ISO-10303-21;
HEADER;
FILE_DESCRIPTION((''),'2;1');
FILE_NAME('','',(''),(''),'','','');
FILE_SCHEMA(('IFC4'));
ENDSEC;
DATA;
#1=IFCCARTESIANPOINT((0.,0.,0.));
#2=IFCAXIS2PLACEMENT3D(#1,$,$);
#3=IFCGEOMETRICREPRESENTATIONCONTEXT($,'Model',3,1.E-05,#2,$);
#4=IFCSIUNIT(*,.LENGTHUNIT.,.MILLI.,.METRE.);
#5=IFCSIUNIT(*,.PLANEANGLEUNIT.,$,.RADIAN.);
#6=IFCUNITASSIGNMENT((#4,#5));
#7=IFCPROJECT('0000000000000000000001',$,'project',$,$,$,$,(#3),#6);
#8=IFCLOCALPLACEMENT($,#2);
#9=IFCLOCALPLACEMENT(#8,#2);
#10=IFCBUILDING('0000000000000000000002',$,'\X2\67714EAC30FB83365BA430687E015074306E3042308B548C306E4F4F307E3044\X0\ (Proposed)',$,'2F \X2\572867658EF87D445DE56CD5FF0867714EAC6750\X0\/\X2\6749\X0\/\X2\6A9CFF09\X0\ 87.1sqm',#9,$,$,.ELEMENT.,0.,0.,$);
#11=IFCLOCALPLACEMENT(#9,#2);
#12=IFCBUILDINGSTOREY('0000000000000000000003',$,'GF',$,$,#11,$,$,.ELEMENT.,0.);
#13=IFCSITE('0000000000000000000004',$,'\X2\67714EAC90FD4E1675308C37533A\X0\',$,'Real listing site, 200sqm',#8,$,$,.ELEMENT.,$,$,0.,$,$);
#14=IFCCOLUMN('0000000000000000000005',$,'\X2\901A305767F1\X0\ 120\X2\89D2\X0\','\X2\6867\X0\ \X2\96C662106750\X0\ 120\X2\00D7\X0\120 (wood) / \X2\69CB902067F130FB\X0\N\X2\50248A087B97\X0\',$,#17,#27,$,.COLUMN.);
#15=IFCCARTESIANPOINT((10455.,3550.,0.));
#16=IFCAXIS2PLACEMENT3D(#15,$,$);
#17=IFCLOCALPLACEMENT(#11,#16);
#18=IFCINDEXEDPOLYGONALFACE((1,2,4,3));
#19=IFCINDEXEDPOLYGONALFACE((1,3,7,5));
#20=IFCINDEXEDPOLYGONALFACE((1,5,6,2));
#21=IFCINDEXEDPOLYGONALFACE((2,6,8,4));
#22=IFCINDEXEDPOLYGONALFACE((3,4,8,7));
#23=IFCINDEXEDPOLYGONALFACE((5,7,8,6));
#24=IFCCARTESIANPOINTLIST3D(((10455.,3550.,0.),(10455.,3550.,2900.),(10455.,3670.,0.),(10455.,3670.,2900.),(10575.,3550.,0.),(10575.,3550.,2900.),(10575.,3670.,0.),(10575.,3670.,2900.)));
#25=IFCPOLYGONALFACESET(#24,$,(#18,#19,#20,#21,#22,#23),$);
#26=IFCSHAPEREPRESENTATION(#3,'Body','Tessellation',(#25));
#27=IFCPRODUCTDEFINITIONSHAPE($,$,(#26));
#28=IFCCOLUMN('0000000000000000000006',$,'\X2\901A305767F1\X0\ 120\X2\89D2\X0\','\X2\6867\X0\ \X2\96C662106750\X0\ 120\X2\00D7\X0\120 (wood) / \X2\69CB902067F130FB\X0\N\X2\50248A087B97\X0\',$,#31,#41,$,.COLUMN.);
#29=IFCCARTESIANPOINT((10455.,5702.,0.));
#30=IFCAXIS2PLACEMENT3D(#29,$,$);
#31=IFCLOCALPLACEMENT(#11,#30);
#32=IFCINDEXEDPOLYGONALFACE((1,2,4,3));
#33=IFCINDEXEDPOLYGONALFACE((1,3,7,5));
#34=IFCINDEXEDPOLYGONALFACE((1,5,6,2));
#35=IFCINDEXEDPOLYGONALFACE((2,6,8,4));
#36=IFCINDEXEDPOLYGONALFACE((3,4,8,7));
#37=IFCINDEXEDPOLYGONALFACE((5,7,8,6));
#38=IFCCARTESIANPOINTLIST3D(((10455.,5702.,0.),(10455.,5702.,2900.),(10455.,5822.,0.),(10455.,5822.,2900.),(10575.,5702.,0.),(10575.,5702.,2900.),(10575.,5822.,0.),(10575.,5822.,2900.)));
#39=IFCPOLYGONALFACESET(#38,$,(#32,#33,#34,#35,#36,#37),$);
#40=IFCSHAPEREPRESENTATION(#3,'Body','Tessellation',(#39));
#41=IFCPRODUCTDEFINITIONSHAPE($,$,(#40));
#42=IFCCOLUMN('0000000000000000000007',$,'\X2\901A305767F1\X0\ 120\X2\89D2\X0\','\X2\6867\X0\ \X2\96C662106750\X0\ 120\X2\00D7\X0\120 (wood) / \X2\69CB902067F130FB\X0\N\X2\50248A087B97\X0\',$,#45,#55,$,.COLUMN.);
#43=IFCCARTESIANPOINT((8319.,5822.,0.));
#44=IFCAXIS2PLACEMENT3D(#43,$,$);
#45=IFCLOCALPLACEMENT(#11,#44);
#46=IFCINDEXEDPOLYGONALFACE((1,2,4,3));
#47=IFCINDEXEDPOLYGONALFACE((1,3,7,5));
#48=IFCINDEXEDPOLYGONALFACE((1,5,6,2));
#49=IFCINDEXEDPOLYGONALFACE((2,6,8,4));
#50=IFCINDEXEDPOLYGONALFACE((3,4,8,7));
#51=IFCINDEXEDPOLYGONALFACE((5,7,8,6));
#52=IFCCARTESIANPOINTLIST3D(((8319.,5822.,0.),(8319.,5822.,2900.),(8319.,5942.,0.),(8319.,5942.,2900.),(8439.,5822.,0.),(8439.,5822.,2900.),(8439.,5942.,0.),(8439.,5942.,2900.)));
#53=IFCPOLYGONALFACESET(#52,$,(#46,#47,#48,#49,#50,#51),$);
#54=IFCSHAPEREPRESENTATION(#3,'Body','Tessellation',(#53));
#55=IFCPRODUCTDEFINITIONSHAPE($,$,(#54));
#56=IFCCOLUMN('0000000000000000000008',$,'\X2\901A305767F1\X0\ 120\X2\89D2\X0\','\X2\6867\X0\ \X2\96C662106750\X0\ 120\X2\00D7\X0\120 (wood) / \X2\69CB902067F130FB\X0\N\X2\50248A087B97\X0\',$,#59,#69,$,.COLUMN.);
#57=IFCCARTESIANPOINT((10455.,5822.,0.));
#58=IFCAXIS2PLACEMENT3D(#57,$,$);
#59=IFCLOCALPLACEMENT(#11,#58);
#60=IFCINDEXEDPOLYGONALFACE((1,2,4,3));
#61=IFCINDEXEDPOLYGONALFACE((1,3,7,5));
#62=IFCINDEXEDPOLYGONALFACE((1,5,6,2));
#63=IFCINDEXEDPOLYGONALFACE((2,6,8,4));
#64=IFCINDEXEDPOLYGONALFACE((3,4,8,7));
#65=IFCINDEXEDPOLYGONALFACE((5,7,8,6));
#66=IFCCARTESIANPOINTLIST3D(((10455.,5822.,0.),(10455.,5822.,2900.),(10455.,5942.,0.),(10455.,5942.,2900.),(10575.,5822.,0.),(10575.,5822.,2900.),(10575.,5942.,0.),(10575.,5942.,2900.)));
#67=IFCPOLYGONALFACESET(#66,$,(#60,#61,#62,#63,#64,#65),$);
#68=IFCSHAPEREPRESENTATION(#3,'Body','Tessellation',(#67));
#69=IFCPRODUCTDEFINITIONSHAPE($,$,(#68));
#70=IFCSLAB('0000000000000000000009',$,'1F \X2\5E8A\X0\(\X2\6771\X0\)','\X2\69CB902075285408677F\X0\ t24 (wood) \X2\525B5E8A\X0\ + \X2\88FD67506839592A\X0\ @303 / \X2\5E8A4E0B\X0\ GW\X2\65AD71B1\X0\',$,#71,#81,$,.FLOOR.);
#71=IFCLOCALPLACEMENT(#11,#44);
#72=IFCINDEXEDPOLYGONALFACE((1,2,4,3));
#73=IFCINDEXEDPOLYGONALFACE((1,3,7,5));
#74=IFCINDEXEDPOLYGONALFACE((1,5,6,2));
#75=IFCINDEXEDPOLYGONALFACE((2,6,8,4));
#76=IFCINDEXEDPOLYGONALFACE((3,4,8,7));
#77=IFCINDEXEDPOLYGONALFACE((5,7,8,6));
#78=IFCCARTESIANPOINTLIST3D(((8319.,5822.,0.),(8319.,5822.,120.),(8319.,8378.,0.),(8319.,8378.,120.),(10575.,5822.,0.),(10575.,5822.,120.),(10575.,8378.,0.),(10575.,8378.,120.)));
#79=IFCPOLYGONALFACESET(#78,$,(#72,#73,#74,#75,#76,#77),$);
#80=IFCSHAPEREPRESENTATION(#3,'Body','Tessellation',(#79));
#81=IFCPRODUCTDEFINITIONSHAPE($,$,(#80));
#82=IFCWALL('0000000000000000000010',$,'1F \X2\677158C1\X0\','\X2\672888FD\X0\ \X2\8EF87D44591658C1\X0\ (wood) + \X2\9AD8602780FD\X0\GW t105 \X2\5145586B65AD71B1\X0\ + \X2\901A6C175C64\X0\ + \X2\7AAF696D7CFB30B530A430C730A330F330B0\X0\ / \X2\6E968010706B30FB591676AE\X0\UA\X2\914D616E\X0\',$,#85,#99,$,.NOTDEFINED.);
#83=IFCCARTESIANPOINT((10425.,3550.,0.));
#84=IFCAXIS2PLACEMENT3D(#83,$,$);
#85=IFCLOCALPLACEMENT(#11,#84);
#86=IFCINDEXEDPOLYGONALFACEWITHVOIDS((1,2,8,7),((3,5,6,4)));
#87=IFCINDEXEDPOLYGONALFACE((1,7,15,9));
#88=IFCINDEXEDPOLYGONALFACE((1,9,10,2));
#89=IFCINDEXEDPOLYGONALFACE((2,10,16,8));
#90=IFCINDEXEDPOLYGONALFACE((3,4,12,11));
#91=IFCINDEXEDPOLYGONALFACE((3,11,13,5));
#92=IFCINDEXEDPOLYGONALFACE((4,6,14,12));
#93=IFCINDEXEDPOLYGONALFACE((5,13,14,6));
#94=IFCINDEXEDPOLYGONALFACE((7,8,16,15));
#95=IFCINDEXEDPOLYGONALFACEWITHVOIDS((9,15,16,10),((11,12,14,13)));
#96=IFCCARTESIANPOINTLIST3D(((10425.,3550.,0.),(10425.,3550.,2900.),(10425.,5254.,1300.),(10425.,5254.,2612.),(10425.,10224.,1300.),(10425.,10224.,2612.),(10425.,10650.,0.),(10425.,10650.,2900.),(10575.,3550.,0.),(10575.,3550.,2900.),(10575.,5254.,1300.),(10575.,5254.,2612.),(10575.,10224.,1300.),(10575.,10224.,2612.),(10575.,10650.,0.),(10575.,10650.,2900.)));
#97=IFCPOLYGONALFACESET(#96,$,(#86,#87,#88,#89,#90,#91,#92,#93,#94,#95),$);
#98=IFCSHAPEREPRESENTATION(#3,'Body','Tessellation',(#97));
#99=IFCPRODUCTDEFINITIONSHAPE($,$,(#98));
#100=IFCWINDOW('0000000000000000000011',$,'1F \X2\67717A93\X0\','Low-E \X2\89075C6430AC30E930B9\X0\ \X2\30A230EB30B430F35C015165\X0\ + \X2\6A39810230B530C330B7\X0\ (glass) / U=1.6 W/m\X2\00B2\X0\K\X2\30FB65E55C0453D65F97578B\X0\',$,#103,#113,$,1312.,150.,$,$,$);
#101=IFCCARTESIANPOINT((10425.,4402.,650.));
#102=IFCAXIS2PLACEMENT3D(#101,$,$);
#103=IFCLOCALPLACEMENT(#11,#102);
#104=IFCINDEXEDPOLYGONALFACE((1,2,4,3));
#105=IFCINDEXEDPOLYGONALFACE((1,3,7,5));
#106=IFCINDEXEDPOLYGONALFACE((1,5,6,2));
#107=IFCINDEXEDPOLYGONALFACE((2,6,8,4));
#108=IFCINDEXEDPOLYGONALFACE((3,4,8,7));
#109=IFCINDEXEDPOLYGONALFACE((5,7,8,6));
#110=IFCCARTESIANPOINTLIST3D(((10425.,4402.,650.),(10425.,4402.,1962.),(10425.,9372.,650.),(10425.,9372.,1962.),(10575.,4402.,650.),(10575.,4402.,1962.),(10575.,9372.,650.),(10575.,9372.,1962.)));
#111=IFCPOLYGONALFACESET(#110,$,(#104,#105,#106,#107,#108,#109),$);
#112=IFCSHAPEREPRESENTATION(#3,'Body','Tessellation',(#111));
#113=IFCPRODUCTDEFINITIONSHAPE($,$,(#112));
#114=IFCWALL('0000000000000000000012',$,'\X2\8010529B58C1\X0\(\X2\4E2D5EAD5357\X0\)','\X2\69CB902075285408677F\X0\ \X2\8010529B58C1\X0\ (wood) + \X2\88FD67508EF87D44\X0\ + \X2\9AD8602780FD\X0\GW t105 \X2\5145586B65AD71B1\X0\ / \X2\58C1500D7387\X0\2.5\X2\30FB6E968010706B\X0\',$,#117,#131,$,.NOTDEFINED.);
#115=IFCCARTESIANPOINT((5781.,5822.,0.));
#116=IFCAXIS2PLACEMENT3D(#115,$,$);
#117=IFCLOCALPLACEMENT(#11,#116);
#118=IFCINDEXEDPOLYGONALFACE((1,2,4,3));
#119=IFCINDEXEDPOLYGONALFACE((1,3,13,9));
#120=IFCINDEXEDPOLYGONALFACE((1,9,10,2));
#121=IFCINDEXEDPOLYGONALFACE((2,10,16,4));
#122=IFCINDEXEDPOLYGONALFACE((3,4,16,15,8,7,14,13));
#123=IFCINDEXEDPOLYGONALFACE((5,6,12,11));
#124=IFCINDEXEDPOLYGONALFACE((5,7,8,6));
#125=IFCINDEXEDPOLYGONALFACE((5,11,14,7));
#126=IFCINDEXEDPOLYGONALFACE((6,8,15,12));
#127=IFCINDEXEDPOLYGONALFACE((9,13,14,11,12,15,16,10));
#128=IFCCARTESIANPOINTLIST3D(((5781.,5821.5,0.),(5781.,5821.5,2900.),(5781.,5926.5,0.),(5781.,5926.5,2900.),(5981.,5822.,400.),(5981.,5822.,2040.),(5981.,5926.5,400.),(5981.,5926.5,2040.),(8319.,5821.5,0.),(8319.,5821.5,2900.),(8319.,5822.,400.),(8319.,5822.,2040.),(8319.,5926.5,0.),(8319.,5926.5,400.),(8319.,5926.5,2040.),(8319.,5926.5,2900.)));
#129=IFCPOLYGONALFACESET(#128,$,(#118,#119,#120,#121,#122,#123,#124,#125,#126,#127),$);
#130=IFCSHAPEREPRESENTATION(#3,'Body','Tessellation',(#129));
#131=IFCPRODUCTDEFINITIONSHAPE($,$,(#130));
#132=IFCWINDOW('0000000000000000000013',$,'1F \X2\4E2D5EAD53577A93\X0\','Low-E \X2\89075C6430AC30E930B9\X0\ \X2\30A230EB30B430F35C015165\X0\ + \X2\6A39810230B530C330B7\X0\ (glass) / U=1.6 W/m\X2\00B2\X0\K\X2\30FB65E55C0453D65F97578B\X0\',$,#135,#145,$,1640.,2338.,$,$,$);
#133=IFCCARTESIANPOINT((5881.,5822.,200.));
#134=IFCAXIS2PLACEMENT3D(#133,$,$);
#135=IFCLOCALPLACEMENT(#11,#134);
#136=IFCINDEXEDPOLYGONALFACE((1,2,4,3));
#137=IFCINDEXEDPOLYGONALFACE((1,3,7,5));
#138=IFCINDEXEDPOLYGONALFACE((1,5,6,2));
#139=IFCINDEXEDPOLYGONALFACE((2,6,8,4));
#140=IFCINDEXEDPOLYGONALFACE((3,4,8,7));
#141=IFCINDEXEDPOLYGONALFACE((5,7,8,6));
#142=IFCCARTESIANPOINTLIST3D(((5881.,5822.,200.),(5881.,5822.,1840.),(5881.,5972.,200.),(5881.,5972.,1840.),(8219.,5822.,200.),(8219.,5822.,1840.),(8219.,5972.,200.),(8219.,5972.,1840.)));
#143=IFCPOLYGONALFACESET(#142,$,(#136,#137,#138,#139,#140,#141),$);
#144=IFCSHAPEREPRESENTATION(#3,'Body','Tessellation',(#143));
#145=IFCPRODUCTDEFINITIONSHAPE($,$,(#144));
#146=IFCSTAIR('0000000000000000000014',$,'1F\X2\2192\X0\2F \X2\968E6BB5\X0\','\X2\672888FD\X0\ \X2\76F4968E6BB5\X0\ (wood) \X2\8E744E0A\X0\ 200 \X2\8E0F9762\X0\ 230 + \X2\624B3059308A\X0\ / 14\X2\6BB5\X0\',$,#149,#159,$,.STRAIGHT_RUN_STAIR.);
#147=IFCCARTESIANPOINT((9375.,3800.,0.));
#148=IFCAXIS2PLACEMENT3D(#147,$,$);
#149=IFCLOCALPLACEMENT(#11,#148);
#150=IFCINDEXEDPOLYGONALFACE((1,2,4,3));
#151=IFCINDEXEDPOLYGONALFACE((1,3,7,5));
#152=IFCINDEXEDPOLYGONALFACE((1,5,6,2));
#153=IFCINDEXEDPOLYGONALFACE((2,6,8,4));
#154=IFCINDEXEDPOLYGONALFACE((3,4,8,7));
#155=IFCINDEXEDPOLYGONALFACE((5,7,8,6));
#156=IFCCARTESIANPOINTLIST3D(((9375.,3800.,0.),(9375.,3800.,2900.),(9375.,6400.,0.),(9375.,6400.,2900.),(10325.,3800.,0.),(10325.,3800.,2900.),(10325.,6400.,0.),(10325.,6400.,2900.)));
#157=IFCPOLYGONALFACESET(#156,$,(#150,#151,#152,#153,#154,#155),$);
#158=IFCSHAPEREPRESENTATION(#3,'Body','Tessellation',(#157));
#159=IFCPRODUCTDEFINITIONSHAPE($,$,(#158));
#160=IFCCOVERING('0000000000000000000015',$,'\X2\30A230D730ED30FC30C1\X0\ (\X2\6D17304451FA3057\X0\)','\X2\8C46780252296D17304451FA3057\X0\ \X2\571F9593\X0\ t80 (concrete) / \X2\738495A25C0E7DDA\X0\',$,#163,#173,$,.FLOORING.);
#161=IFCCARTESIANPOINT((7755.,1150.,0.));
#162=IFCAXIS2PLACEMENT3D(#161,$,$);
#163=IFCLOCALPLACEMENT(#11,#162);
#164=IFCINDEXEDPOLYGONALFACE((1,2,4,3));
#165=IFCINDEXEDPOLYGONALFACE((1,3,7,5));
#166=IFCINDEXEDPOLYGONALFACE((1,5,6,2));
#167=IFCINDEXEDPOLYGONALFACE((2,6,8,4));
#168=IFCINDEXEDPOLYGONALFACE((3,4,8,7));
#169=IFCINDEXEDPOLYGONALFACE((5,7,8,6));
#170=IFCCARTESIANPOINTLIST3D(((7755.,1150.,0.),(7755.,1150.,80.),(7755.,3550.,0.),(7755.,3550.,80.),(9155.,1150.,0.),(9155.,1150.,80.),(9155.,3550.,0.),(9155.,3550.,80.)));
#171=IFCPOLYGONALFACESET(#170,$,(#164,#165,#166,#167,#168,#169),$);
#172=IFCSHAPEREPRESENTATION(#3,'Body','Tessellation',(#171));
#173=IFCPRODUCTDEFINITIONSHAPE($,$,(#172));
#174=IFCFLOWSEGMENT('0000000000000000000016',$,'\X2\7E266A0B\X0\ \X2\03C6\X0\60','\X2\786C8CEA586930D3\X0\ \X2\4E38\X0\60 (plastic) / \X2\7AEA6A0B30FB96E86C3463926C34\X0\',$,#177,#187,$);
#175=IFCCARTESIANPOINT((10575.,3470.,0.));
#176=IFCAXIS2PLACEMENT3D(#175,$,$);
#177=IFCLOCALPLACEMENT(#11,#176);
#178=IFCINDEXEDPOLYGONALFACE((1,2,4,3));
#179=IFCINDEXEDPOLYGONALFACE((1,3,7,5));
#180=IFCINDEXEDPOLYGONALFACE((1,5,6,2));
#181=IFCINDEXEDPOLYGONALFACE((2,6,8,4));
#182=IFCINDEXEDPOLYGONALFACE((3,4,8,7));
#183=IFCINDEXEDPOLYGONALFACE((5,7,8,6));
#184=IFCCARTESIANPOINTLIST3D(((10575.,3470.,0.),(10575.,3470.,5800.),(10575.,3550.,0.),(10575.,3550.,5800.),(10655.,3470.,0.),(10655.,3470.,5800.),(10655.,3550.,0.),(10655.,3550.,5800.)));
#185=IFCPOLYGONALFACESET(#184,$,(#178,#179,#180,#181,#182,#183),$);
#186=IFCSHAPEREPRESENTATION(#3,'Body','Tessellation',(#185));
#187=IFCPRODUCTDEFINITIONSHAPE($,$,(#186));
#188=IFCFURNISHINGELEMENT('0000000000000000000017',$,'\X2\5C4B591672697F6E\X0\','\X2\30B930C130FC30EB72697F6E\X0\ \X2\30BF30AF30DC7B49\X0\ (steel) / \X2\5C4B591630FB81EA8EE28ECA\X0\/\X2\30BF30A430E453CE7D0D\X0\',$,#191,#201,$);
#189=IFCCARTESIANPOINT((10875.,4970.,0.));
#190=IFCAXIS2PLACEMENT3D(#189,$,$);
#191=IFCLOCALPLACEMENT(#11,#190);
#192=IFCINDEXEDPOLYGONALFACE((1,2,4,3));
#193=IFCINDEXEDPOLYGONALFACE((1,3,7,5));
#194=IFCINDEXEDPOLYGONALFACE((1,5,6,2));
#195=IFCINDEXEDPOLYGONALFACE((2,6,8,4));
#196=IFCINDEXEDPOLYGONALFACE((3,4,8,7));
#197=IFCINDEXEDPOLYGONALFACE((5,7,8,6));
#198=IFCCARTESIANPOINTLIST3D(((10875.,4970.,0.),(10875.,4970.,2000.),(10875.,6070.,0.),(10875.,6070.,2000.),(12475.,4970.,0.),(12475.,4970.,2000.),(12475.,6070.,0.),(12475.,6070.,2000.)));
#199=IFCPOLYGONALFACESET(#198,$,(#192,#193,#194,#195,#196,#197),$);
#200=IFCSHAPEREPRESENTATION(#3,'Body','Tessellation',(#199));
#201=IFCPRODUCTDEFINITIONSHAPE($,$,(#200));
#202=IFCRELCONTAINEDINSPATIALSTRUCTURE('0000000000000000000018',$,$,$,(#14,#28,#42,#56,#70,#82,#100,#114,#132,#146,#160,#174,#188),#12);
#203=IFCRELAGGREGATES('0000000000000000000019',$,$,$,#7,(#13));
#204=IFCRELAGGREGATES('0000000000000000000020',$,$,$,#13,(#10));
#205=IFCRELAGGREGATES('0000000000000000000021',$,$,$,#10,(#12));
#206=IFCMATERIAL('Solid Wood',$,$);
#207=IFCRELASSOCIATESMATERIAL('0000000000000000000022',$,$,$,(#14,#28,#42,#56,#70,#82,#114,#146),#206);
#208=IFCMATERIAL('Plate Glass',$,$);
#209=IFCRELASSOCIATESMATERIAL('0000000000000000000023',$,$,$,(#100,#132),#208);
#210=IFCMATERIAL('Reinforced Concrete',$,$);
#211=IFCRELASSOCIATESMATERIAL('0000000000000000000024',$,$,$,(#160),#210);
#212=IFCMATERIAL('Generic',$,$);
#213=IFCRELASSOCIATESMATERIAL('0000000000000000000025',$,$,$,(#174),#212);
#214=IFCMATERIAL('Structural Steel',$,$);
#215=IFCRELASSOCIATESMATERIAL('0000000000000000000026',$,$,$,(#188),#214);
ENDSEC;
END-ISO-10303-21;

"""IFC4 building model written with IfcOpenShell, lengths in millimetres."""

from ifc_helpers import new_model, si_unit, frame, frame_2d, origin, place, context, project, spatial, rectangle, extrude, material, element, fill, save


model = new_model("IFC4")

# Units and contexts
model_context = context("Model", 3, precision=1e-05, world=origin())
ifc_project = project(units=[si_unit("LENGTHUNIT", "METRE", prefix="MILLI"), si_unit("PLANEANGLEUNIT", "RADIAN")], contexts=[model_context])

# Site, building, storey
site_placement = place(None, origin())
site = spatial("IfcSite", under=ifc_project, at=site_placement, Name="東京都世田谷区", ObjectType="Real listing site, 200sqm", CompositionType="ELEMENT", RefElevation=0.0)
building_placement = place(site_placement, origin())
building = spatial("IfcBuilding", under=site, at=building_placement, Name="東京・茶室と縁側のある和の住まい (Proposed)", ObjectType="2F 在来軸組工法（東京材/杉/檜） 87.1sqm", CompositionType="ELEMENT", ElevationOfRefHeight=0.0, ElevationOfTerrain=0.0)
storey_placement = place(building_placement, origin())
storey = spatial("IfcBuildingStorey", under=building, at=storey_placement, Name="GF", CompositionType="ELEMENT", Elevation=0.0)

# Columns
ifc_material_1 = material(Name="Solid Wood")
column_1_placement = place(storey_placement, frame((10455.0, 3550.0, 0.0)))
element("IfcColumn", 1, at=column_1_placement, inside=storey, material=ifc_material_1, Name="通し柱 120角", Description="桧 集成材 120×120 (wood) / 構造柱・N値計算", PredefinedType="COLUMN", context=model_context, shape_type="SweptSolid", body=[
    extrude(rectangle(XDim=120.0, YDim=120.0, at=frame_2d((60.0, 60.0))), frame((10455.0, 3550.0, 0.0)), (0.0, 0.0, 1.0), 2900.0),
])
column_2_placement = place(storey_placement, frame((10455.0, 5702.0, 0.0)))
element("IfcColumn", 2, at=column_2_placement, inside=storey, material=ifc_material_1, Name="通し柱 120角", Description="桧 集成材 120×120 (wood) / 構造柱・N値計算", PredefinedType="COLUMN", context=model_context, shape_type="SweptSolid", body=[
    extrude(rectangle(XDim=120.0, YDim=120.0, at=frame_2d((60.0, 60.0))), frame((10455.0, 5702.0, 0.0)), (0.0, 0.0, 1.0), 2900.0),
])
column_3_placement = place(storey_placement, frame((8319.0, 5822.0, 0.0)))
element("IfcColumn", 3, at=column_3_placement, inside=storey, material=ifc_material_1, Name="通し柱 120角", Description="桧 集成材 120×120 (wood) / 構造柱・N値計算", PredefinedType="COLUMN", context=model_context, shape_type="SweptSolid", body=[
    extrude(rectangle(XDim=120.0, YDim=120.0, at=frame_2d((60.0, 60.0))), frame((8319.0, 5822.0, 0.0)), (0.0, 0.0, 1.0), 2900.0),
])
column_4_placement = place(storey_placement, frame((10455.0, 5822.0, 0.0)))
element("IfcColumn", 4, at=column_4_placement, inside=storey, material=ifc_material_1, Name="通し柱 120角", Description="桧 集成材 120×120 (wood) / 構造柱・N値計算", PredefinedType="COLUMN", context=model_context, shape_type="SweptSolid", body=[
    extrude(rectangle(XDim=120.0, YDim=120.0, at=frame_2d((60.0, 60.0))), frame((10455.0, 5822.0, 0.0)), (0.0, 0.0, 1.0), 2900.0),
])

# Slab
slab_placement = place(storey_placement, frame((8319.0, 5822.0, 0.0)))
element("IfcSlab", 5, at=slab_placement, inside=storey, material=ifc_material_1, Name="1F 床(東)", Description="構造用合板 t24 (wood) 剛床 + 製材根太 @303 / 床下 GW断熱", PredefinedType="FLOOR", context=model_context, shape_type="SweptSolid", body=[
    extrude(rectangle(XDim=2256.0, YDim=2556.0, at=frame_2d((1128.0, 1278.0))), frame((8319.0, 5822.0, 0.0)), (0.0, 0.0, 1.0), 120.0),
])

# Walls, openings, windows
wall_1_placement = place(storey_placement, frame((10425.0, 3550.0, 0.0)))
wall_1 = element("IfcWall", 6, at=wall_1_placement, inside=storey, material=ifc_material_1, Name="1F 東壁", Description="木製 軸組外壁 (wood) + 高性能GW t105 充填断熱 + 通気層 + 窯業系サイディング / 準耐火・外皮UA配慮", PredefinedType="NOTDEFINED", context=model_context, shape_type="SweptSolid", body=[
    extrude(rectangle(XDim=150.0, YDim=7100.0, at=frame_2d((75.0, 3550.0))), frame((10425.0, 3550.0, 0.0)), (0.0, 0.0, 1.0), 2900.0),
])
opening_1_placement = place(storey_placement, frame((10425.0, 4402.0, 650.0)))
opening_1 = element("IfcOpeningElement", 7, at=opening_1_placement, cuts=wall_1, PredefinedType="NOTDEFINED", context=model_context, shape_type="SweptSolid", body=[
    extrude(rectangle(XDim=150.0, YDim=4970.0, at=frame_2d((75.0, 2485.0))), frame((10425.0, 4402.0, 650.0)), (0.0, 0.0, 1.0), 1312.0),
])
ifc_material_2 = material(Name="Plate Glass")
window_1_placement = place(storey_placement, frame((10425.0, 4402.0, 650.0)))
window_1 = element("IfcWindow", 8, at=window_1_placement, inside=storey, material=ifc_material_2, Name="1F 東窓", Description="Low-E 複層ガラス アルゴン封入 + 樹脂サッシ (glass) / U=1.6 W/m²K・日射取得型", OverallHeight=1312.0, OverallWidth=150.0, context=model_context, shape_type="SweptSolid", body=[
    extrude(rectangle(XDim=150.0, YDim=4970.0, at=frame_2d((75.0, 2485.0))), frame((10425.0, 4402.0, 650.0)), (0.0, 0.0, 1.0), 1312.0),
])
fill(opening_1, window_1)
wall_2_placement = place(storey_placement, frame((5781.0, 5822.0, 0.0)))
wall_2 = element("IfcWall", 9, at=wall_2_placement, inside=storey, material=ifc_material_1, Name="耐力壁(中庭南)", Description="構造用合板 耐力壁 (wood) + 製材軸組 + 高性能GW t105 充填断熱 / 壁倍率2.5・準耐火", PredefinedType="NOTDEFINED", context=model_context, shape_type="SweptSolid", body=[
    extrude(rectangle(XDim=2538.0, YDim=105.0, at=frame_2d((1269.0, 52.0))), frame((5781.0, 5822.0, 0.0)), (0.0, 0.0, 1.0), 2900.0),
])
opening_2_placement = place(storey_placement, frame((5881.0, 5822.0, 200.0)))
opening_2 = element("IfcOpeningElement", 10, at=opening_2_placement, cuts=wall_2, PredefinedType="NOTDEFINED", context=model_context, shape_type="SweptSolid", body=[
    extrude(rectangle(XDim=2338.0, YDim=150.0, at=frame_2d((1169.0, 75.0))), frame((5881.0, 5822.0, 200.0)), (0.0, 0.0, 1.0), 1640.0),
])
window_2_placement = place(storey_placement, frame((5881.0, 5822.0, 200.0)))
window_2 = element("IfcWindow", 11, at=window_2_placement, inside=storey, material=ifc_material_2, Name="1F 中庭南窓", Description="Low-E 複層ガラス アルゴン封入 + 樹脂サッシ (glass) / U=1.6 W/m²K・日射取得型", OverallHeight=1640.0, OverallWidth=2338.0, context=model_context, shape_type="SweptSolid", body=[
    extrude(rectangle(XDim=2338.0, YDim=150.0, at=frame_2d((1169.0, 75.0))), frame((5881.0, 5822.0, 200.0)), (0.0, 0.0, 1.0), 1640.0),
])
fill(opening_2, window_2)

# Stair
stair_placement = place(storey_placement, frame((9375.0, 3800.0, 0.0)))
element("IfcStair", 12, at=stair_placement, inside=storey, material=ifc_material_1, Name="1F→2F 階段", Description="木製 直階段 (wood) 蹴上 200 踏面 230 + 手すり / 14段", PredefinedType="STRAIGHT_RUN_STAIR", context=model_context, shape_type="SweptSolid", body=[
    extrude(rectangle(XDim=950.0, YDim=2600.0, at=frame_2d((475.0, 1300.0))), frame((9375.0, 3800.0, 0.0)), (0.0, 0.0, 1.0), 2900.0),
])

# Covering
ifc_material_3 = material(Name="Reinforced Concrete")
covering_placement = place(storey_placement, frame((7755.0, 1150.0, 0.0)))
element("IfcCovering", 13, at=covering_placement, inside=storey, material=ifc_material_3, Name="アプローチ (洗い出し)", Description="豆砂利洗い出し 土間 t80 (concrete) / 玄関導線", PredefinedType="FLOORING", context=model_context, shape_type="SweptSolid", body=[
    extrude(rectangle(XDim=1400.0, YDim=2400.0, at=frame_2d((700.0, 1200.0))), frame((7755.0, 1150.0, 0.0)), (0.0, 0.0, 1.0), 80.0),
])

# Flow segment
ifc_material_4 = material(Name="Generic")
flow_segment_placement = place(storey_placement, frame((10575.0, 3470.0, 0.0)))
element("IfcFlowSegment", 14, at=flow_segment_placement, inside=storey, material=ifc_material_4, Name="縦樋 φ60", Description="硬質塩ビ 丸60 (plastic) / 竪樋・雨水排水", context=model_context, shape_type="SweptSolid", body=[
    extrude(rectangle(XDim=80.0, YDim=80.0, at=frame_2d((40.0, 40.0))), frame((10575.0, 3470.0, 0.0)), (0.0, 0.0, 1.0), 5800.0),
])

# Furnishing element
ifc_material_5 = material(Name="Structural Steel")
furnishing_placement = place(storey_placement, frame((10875.0, 4970.0, 0.0)))
element("IfcFurnishingElement", 15, at=furnishing_placement, inside=storey, material=ifc_material_5, Name="屋外物置", Description="スチール物置 タクボ等 (steel) / 屋外・自転車/タイヤ収納", context=model_context, shape_type="SweptSolid", body=[
    extrude(rectangle(XDim=1600.0, YDim=1100.0, at=frame_2d((800.0, 550.0))), frame((10875.0, 4970.0, 0.0)), (0.0, 0.0, 1.0), 2000.0),
])

save(model, "model.ifc")
